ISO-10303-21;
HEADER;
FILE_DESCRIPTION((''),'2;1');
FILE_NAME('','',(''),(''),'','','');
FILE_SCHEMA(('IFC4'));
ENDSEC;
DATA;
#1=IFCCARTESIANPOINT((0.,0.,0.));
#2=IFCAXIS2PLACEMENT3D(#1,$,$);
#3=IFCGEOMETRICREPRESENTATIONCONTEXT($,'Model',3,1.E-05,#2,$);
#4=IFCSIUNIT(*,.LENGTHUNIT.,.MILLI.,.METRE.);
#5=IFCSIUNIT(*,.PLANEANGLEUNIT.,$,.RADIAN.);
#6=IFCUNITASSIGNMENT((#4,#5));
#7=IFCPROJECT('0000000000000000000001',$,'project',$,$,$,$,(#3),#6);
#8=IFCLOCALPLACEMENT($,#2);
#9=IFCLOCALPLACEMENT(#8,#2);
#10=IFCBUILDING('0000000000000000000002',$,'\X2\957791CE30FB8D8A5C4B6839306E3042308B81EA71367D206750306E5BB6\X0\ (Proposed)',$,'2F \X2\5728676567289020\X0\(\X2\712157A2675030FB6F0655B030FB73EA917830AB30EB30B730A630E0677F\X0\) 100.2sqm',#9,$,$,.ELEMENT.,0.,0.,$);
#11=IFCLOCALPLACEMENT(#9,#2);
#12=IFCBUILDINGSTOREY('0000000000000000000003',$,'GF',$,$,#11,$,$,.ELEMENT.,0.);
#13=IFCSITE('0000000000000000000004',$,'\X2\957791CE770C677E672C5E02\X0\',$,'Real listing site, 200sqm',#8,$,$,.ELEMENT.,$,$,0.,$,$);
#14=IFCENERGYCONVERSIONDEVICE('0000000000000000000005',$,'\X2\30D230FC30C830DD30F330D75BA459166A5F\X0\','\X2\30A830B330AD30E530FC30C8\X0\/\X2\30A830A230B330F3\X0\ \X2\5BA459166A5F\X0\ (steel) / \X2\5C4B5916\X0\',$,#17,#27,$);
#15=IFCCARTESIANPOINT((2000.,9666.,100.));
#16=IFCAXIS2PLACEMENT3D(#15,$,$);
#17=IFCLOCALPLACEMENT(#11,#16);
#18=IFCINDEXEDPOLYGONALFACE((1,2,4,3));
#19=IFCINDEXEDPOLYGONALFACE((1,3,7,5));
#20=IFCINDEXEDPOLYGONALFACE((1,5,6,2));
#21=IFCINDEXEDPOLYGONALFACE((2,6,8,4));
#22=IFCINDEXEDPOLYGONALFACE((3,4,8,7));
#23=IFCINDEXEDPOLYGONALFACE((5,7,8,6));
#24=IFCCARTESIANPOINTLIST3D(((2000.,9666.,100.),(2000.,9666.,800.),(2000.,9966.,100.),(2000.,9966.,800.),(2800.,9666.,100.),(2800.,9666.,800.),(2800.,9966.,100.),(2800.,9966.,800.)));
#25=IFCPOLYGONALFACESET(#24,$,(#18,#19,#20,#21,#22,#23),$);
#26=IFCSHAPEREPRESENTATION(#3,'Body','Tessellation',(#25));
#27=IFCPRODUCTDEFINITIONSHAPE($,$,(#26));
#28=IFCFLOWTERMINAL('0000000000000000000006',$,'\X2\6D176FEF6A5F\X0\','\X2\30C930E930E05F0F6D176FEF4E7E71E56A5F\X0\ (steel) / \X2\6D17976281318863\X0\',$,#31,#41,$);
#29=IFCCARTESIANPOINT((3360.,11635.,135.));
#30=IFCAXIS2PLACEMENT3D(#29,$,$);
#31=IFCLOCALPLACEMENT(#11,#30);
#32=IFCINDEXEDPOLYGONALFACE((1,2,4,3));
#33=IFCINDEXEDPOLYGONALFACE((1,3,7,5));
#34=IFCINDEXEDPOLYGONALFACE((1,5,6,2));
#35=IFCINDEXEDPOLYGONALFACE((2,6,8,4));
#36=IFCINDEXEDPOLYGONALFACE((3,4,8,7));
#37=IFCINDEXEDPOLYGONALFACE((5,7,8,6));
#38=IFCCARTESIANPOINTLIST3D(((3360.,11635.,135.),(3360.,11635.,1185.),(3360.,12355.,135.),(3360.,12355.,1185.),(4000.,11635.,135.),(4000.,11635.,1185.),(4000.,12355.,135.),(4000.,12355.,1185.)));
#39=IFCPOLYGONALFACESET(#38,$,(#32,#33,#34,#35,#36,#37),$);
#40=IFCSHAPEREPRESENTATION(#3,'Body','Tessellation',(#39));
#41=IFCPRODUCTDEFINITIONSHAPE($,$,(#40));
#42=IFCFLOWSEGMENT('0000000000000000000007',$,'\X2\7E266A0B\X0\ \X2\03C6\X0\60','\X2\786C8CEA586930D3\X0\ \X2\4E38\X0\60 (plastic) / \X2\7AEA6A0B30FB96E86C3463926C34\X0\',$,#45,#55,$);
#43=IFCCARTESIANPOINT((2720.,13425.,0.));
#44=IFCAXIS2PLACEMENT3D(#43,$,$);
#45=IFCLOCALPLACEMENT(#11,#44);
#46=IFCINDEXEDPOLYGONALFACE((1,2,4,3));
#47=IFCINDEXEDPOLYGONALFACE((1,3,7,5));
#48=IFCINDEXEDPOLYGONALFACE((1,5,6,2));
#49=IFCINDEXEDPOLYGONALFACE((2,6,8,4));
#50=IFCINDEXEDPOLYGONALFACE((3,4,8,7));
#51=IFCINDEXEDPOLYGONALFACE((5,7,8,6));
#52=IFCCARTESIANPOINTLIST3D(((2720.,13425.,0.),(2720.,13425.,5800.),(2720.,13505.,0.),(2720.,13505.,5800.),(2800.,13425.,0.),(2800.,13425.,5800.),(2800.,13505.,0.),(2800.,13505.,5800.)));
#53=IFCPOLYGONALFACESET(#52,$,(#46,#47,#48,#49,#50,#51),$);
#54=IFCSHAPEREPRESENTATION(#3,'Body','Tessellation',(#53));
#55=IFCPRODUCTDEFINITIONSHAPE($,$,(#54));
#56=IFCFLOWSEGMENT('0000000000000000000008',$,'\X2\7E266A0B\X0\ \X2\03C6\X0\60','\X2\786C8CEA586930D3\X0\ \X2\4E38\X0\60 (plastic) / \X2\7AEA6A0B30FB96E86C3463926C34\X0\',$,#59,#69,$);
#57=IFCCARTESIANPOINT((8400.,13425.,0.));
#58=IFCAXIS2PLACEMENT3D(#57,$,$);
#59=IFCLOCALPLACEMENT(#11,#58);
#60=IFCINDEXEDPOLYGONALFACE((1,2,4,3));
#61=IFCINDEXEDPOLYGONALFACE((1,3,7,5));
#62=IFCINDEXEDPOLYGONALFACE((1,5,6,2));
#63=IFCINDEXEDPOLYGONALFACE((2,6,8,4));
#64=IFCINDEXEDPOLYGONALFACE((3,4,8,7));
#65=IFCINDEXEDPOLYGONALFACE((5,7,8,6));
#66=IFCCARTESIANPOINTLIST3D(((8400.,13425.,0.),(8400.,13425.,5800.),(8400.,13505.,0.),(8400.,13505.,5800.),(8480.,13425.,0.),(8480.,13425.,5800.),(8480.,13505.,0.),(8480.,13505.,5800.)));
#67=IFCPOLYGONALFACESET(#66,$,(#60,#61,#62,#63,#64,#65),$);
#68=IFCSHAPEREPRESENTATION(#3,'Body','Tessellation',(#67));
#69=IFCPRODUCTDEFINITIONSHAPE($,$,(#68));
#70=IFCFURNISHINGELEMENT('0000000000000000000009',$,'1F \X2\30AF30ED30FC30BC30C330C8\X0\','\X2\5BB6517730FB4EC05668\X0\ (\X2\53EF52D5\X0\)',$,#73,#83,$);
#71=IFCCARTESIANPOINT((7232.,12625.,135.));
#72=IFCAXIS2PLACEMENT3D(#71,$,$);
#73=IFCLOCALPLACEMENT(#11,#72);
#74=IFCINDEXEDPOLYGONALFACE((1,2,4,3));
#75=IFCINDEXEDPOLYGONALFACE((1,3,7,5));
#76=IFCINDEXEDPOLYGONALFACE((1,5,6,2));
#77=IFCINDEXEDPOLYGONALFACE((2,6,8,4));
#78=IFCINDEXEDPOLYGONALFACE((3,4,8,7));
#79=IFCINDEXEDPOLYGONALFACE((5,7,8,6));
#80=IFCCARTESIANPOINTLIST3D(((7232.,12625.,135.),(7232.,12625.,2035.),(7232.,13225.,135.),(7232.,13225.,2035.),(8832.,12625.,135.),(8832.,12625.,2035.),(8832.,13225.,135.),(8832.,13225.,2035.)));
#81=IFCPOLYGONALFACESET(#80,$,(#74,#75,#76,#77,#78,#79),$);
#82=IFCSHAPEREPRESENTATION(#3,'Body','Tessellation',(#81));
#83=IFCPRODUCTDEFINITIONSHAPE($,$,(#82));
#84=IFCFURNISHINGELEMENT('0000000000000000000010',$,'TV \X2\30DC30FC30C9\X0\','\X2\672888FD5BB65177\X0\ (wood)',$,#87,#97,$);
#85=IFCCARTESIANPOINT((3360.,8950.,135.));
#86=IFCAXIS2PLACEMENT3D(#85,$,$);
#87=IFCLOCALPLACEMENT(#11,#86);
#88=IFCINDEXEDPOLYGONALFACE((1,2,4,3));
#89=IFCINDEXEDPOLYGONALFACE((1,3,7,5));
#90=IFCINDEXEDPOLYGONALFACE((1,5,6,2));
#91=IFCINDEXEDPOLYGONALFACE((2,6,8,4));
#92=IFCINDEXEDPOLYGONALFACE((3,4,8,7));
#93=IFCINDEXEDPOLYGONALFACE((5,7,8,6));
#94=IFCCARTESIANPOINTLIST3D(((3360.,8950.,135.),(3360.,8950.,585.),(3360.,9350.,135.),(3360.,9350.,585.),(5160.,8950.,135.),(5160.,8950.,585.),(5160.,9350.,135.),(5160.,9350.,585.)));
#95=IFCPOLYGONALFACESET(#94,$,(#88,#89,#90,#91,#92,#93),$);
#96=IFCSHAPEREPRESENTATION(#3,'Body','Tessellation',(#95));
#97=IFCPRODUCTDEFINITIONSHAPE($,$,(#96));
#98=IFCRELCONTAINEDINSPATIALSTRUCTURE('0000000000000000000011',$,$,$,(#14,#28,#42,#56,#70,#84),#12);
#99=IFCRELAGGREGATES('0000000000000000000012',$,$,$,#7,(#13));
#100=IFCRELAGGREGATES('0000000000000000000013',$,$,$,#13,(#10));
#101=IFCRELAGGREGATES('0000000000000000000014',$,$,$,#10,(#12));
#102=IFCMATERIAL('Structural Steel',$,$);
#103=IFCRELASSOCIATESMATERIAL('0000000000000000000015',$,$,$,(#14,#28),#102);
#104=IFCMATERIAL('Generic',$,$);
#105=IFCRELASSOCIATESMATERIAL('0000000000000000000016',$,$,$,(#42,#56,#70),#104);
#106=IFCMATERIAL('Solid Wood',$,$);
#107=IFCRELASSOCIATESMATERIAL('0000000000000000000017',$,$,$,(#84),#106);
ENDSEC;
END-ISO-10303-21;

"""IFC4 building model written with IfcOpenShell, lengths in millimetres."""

from ifc_helpers import new_model, si_unit, frame, frame_2d, origin, place, context, project, spatial, rectangle, extrude, material, element, save


model = new_model("IFC4")

# Units and contexts
model_context = context("Model", 3, precision=1e-05, world=origin())
ifc_project = project(units=[si_unit("LENGTHUNIT", "METRE", prefix="MILLI"), si_unit("PLANEANGLEUNIT", "RADIAN")], contexts=[model_context])

# Site, building, storey
site_placement = place(None, origin())
site = spatial("IfcSite", under=ifc_project, at=site_placement, Name="長野県松本市", ObjectType="Real listing site, 200sqm", CompositionType="ELEMENT", RefElevation=0.0)
building_placement = place(site_placement, origin())
building = spatial("IfcBuilding", under=site, at=building_placement, Name="長野・越屋根のある自然素材の家 (Proposed)", ObjectType="2F 在来木造(無垢材・漆喰・珪酸カルシウム板) 100.2sqm", CompositionType="ELEMENT", ElevationOfRefHeight=0.0, ElevationOfTerrain=0.0)
storey_placement = place(building_placement, origin())
storey = spatial("IfcBuildingStorey", under=building, at=storey_placement, Name="GF", CompositionType="ELEMENT", Elevation=0.0)

# Shared definitions
ifc_material_1 = material(Name="Solid Wood")

# Shared definitions
ifc_material_2 = material(Name="Generic")

# Shared definitions
ifc_material_3 = material(Name="Structural Steel")

# Energy conversion device
energy_conversion_device_placement = place(storey_placement, frame((2000.0, 9666.0, 100.0)))
element("IfcEnergyConversionDevice", 1, at=energy_conversion_device_placement, inside=storey, material=ifc_material_3, Name="ヒートポンプ室外機", Description="エコキュート/エアコン 室外機 (steel) / 屋外", context=model_context, shape_type="SweptSolid", body=[
    extrude(rectangle(XDim=800.0, YDim=300.0, at=frame_2d((400.0, 150.0))), frame((2000.0, 9666.0, 100.0)), (0.0, 0.0, 1.0), 700.0),
])

# Flow terminal
flow_terminal_placement = place(storey_placement, frame((3360.0, 11635.0, 135.0)))
element("IfcFlowTerminal", 2, at=flow_terminal_placement, inside=storey, material=ifc_material_3, Name="洗濯機", Description="ドラム式洗濯乾燥機 (steel) / 洗面脱衣", context=model_context, shape_type="SweptSolid", body=[
    extrude(rectangle(XDim=640.0, YDim=720.0, at=frame_2d((320.0, 360.0))), frame((3360.0, 11635.0, 135.0)), (0.0, 0.0, 1.0), 1050.0),
])

# Flow segments
flow_segment_1_placement = place(storey_placement, frame((2720.0, 13425.0, 0.0)))
element("IfcFlowSegment", 3, at=flow_segment_1_placement, inside=storey, material=ifc_material_2, Name="縦樋 φ60", Description="硬質塩ビ 丸60 (plastic) / 竪樋・雨水排水", context=model_context, shape_type="SweptSolid", body=[
    extrude(rectangle(XDim=80.0, YDim=80.0, at=frame_2d((40.0, 40.0))), frame((2720.0, 13425.0, 0.0)), (0.0, 0.0, 1.0), 5800.0),
])
flow_segment_2_placement = place(storey_placement, frame((8400.0, 13425.0, 0.0)))
element("IfcFlowSegment", 4, at=flow_segment_2_placement, inside=storey, material=ifc_material_2, Name="縦樋 φ60", Description="硬質塩ビ 丸60 (plastic) / 竪樋・雨水排水", context=model_context, shape_type="SweptSolid", body=[
    extrude(rectangle(XDim=80.0, YDim=80.0, at=frame_2d((40.0, 40.0))), frame((8400.0, 13425.0, 0.0)), (0.0, 0.0, 1.0), 5800.0),
])

# Furnishing elements
furnishing_1_placement = place(storey_placement, frame((7232.0, 12625.0, 135.0)))
element("IfcFurnishingElement", 5, at=furnishing_1_placement, inside=storey, material=ifc_material_2, Name="1F クローゼット", Description="家具・什器 (可動)", context=model_context, shape_type="SweptSolid", body=[
    extrude(rectangle(XDim=1600.0, YDim=600.0, at=frame_2d((800.0, 300.0))), frame((7232.0, 12625.0, 135.0)), (0.0, 0.0, 1.0), 1900.0),
])
furnishing_2_placement = place(storey_placement, frame((3360.0, 8950.0, 135.0)))
element("IfcFurnishingElement", 6, at=furnishing_2_placement, inside=storey, material=ifc_material_1, Name="TV ボード", Description="木製家具 (wood)", context=model_context, shape_type="SweptSolid", body=[
    extrude(rectangle(XDim=1800.0, YDim=400.0, at=frame_2d((900.0, 200.0))), frame((3360.0, 8950.0, 135.0)), (0.0, 0.0, 1.0), 450.0),
])

save(model, "model.ifc")
